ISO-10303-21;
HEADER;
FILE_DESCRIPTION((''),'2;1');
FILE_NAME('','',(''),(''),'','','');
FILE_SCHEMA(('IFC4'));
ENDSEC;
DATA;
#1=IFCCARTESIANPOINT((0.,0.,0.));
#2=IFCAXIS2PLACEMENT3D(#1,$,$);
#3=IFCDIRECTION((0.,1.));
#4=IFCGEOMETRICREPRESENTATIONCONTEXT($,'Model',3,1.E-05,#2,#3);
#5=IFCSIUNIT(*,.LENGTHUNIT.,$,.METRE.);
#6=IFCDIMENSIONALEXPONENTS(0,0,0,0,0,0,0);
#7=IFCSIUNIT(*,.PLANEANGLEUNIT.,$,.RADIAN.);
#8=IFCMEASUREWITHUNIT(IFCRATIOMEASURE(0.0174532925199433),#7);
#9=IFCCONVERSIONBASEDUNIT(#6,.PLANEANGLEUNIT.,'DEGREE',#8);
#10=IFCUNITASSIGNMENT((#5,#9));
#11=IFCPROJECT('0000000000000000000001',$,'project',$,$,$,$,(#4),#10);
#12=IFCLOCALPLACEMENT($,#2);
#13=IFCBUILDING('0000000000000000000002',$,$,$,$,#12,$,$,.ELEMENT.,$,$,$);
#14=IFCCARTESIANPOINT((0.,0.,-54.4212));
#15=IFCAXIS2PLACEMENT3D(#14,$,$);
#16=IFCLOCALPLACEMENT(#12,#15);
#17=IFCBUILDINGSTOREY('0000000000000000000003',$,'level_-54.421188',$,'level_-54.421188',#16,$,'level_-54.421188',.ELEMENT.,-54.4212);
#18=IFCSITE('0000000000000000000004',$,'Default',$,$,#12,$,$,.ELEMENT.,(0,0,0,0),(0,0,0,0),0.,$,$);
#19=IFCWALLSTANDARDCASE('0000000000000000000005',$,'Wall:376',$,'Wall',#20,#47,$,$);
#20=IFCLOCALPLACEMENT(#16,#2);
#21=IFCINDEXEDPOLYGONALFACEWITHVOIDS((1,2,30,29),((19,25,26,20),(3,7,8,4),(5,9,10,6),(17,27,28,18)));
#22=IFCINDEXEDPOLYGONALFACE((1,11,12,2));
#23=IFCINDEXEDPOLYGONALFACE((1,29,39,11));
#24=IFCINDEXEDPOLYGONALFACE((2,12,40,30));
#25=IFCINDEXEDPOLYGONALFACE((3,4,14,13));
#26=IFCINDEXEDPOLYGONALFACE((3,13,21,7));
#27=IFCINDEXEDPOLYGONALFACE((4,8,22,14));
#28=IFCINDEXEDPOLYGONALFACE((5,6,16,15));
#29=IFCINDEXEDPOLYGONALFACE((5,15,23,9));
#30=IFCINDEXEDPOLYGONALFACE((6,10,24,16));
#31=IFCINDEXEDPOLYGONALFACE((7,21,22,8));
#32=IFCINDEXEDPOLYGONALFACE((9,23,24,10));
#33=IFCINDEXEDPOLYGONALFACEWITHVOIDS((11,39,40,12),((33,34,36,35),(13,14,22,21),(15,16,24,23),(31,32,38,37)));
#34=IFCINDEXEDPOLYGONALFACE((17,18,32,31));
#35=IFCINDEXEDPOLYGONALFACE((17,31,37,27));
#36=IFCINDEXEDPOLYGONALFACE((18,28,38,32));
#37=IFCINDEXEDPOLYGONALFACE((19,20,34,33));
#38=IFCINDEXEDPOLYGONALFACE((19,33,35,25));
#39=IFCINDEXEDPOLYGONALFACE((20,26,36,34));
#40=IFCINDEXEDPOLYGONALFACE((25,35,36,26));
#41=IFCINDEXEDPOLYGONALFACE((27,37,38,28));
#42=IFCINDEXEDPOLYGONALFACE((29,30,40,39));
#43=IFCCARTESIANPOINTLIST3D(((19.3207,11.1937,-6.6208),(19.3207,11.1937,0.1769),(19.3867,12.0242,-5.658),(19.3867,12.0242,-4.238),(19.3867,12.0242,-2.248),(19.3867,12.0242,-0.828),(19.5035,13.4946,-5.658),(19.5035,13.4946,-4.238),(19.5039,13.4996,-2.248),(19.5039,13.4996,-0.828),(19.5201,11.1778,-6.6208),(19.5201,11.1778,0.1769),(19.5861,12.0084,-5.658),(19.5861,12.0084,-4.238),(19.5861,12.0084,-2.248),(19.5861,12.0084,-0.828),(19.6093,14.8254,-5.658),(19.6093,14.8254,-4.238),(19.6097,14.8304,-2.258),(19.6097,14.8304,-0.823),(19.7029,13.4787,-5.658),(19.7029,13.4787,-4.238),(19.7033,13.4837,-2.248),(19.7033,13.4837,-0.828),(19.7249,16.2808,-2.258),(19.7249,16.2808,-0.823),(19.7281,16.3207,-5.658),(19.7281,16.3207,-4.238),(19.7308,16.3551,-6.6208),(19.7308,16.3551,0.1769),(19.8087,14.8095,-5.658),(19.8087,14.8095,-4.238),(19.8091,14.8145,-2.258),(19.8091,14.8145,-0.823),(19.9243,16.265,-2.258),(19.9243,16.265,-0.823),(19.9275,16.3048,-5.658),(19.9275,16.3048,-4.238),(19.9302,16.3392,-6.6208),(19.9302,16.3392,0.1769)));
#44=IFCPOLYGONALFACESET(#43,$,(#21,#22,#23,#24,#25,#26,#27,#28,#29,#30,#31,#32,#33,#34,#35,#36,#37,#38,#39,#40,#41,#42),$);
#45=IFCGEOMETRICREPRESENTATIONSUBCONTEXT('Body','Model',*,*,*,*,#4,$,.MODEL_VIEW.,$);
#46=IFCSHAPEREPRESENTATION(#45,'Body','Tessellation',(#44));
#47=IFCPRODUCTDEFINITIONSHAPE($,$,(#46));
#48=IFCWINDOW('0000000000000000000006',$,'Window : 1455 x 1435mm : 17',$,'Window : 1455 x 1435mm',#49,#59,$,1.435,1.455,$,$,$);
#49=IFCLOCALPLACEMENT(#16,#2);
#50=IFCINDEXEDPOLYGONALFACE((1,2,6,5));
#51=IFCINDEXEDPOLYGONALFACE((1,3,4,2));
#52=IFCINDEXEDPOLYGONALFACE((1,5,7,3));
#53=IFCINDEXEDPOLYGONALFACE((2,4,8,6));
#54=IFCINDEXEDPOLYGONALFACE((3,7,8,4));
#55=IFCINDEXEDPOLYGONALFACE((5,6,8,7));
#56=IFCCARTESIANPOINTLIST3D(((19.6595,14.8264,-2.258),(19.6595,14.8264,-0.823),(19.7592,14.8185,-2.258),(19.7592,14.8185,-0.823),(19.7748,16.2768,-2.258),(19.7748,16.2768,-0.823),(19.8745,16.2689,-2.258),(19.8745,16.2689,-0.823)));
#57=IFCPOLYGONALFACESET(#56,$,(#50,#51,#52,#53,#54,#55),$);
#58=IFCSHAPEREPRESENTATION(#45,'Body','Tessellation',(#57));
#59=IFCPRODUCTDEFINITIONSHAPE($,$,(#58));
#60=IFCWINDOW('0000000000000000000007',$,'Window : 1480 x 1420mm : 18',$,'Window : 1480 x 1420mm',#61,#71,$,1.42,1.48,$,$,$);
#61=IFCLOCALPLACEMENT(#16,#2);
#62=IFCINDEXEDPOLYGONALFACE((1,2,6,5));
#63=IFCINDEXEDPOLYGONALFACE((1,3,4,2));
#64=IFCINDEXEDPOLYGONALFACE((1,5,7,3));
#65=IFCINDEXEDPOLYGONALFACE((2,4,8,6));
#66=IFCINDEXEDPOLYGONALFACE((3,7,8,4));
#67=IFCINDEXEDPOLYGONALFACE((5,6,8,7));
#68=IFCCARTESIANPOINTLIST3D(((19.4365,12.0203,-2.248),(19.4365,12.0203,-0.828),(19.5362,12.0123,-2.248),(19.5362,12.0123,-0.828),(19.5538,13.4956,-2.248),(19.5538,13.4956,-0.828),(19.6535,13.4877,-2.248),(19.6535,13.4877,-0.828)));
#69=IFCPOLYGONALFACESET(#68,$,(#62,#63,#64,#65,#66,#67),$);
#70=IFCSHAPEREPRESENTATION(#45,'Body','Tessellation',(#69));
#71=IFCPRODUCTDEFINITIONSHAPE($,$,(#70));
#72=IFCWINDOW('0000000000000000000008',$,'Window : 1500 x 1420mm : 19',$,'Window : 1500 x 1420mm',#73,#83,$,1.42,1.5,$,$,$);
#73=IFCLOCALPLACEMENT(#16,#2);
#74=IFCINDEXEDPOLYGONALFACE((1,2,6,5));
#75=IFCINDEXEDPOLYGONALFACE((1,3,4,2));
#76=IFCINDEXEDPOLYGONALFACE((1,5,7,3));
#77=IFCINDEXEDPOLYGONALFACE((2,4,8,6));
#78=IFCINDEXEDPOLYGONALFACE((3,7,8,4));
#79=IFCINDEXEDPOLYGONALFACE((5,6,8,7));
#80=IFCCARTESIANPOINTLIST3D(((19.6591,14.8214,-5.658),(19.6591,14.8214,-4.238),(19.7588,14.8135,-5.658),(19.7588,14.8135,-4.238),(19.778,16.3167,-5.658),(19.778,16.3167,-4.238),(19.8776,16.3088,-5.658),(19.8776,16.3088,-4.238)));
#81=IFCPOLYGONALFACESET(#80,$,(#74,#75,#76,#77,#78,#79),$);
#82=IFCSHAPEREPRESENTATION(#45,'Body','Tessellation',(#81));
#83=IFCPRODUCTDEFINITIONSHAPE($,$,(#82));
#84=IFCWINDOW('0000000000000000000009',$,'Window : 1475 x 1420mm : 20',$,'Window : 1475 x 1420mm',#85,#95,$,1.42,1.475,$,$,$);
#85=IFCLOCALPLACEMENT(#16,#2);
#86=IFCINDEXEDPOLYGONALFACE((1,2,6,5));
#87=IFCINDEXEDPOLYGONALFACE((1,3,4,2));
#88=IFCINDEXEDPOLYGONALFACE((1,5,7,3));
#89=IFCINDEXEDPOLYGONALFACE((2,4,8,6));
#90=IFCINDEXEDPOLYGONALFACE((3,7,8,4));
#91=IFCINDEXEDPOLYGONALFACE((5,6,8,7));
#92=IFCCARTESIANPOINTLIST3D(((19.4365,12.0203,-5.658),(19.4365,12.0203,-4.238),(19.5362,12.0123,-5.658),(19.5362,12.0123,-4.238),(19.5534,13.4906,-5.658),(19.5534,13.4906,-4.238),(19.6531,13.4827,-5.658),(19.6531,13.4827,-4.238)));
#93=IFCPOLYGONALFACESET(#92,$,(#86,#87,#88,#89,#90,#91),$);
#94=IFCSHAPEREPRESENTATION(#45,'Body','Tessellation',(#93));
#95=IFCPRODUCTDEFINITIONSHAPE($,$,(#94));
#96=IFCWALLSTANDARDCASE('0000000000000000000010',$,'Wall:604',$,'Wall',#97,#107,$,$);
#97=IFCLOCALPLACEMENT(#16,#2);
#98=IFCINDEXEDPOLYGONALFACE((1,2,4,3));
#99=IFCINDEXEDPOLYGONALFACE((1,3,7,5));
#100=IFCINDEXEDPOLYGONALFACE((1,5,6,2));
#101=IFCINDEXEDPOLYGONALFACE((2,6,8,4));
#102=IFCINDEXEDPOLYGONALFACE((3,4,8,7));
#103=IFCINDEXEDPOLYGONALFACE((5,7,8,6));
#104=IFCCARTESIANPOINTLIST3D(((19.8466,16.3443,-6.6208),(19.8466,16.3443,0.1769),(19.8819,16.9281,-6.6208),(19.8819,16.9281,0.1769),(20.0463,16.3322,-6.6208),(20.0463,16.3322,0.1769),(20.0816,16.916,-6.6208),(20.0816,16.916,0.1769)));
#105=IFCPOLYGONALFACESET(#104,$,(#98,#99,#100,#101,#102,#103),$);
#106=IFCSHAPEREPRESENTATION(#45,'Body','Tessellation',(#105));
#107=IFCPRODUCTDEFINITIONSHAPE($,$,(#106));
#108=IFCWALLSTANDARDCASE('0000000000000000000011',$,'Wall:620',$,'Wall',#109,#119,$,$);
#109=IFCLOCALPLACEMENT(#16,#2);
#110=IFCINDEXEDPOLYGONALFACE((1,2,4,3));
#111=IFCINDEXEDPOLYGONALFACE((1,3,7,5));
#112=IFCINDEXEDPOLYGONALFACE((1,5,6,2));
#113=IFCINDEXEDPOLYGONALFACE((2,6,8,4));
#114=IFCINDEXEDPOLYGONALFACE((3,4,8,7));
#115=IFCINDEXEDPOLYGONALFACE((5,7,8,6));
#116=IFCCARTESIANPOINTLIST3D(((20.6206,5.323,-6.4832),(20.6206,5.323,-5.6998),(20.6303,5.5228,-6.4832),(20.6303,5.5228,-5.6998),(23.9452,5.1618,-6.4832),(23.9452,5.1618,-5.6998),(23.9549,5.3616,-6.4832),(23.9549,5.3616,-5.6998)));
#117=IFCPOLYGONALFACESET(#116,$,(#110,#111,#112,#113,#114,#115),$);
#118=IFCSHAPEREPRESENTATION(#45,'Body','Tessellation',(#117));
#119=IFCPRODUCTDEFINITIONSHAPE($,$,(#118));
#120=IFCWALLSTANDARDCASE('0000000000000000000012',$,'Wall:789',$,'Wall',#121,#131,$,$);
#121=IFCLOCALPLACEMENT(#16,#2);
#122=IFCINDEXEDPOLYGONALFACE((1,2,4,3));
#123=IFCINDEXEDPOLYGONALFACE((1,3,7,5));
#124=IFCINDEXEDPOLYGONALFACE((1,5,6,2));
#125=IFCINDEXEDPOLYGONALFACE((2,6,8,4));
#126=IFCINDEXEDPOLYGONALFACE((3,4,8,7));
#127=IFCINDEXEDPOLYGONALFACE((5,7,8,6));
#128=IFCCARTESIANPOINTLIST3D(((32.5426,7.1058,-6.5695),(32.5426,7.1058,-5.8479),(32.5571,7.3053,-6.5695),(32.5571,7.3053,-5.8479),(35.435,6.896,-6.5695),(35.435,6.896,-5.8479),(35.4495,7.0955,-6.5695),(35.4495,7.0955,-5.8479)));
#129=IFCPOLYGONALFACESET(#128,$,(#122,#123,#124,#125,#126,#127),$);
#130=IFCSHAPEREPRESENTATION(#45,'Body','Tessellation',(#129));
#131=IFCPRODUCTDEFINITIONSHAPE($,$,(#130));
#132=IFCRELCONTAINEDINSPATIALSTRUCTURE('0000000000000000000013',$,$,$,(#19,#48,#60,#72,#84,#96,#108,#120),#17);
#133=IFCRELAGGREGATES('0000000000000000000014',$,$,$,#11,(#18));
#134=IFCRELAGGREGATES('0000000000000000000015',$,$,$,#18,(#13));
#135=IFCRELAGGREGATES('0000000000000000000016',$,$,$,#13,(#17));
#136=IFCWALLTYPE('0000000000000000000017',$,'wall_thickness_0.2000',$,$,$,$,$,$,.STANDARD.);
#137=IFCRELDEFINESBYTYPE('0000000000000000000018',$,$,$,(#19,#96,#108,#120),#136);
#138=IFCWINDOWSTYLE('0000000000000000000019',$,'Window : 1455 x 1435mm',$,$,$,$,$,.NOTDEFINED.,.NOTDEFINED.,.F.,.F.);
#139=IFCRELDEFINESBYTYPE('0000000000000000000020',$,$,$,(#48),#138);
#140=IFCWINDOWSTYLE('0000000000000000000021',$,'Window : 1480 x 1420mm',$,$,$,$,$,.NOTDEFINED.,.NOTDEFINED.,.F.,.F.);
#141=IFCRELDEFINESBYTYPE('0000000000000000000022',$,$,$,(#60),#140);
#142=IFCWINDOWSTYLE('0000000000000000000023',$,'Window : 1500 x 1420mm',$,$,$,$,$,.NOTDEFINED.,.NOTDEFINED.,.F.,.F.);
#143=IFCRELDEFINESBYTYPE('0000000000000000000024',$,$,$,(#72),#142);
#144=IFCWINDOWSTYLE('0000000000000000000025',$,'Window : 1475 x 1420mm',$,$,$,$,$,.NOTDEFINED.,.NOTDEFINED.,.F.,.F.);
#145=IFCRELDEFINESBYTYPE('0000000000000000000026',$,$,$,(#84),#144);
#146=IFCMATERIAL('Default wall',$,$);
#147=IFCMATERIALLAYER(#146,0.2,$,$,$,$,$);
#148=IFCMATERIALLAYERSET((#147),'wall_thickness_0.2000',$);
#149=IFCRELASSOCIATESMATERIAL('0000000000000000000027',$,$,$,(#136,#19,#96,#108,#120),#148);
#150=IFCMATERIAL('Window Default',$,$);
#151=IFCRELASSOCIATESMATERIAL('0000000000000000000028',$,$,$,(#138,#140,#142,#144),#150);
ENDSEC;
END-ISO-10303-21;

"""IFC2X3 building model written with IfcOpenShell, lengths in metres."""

from ifc_helpers import new_model, entity, si_unit, converted_unit, direction, frame, frame_2d, origin, origin_2d_with_axis, place, context, subcontext, project, spatial, polyline, rectangle, outline, extrude, source, transform, mapped, material, layer, layer_set, layer_usage, type_object, type_shapes, element, fill, save


model = new_model("IFC2X3")

# Units and contexts
model_context = context("Model", 3, precision=1e-05, world=origin(), true_north=direction((0.0, 1.0)))
body_context = subcontext(model_context, "Body", "Model", "MODEL_VIEW")
ifc_project = project(units=[si_unit("LENGTHUNIT", "METRE"), converted_unit("PLANEANGLEUNIT", "DEGREE", entity("IfcRatioMeasure", 0.0174532925199433), si_unit("PLANEANGLEUNIT", "RADIAN"), dimensions=[0, 0, 0, 0, 0, 0, 0])], contexts=[model_context])

# Site, building, storey
placement_1 = place(None, origin())
site = spatial("IfcSite", under=ifc_project, at=placement_1, Name="Default", CompositionType="ELEMENT", RefLatitude=(0, 0, 0, 0), RefLongitude=(0, 0, 0, 0), RefElevation=0.0)
building = spatial("IfcBuilding", under=site, at=placement_1, CompositionType="ELEMENT")
storey_placement = place(placement_1, frame((0.0, 0.0, -54.4212)))
storey = spatial("IfcBuildingStorey", under=building, at=storey_placement, Name="level_-54.421188", ObjectType="level_-54.421188", LongName="level_-54.421188", CompositionType="ELEMENT", Elevation=-54.4212)

# Wall, openings, windows
ifc_material_1 = material(Name="Default wall")
ifc_layer = layer(ifc_material_1, 0.2)
ifc_layer_set = layer_set([ifc_layer], Name="wall_thickness_0.2000")
ifc_layer_usage = layer_usage(ifc_layer_set, "AXIS2", "POSITIVE", -0.1)
wall_type = type_object("IfcWallType", Name="wall_thickness_0.2000", PredefinedType="STANDARD", material=ifc_layer_set)
placement_2 = place(placement_1, frame((0.0, 0.0, -61.042)))
wall_1_placement = place(placement_2, frame((19.8305, 16.3471, 0.0), z_axis=(0.0, 0.0, 1.0), x_axis=(-0.079214, -0.996858, 0.0)))
wall_1 = element("IfcWallStandardCase", 1, at=wall_1_placement, inside=storey, type_object=wall_type, material=ifc_layer_usage, Name="Wall:376", ObjectType="Wall", context=body_context, shape_type="SweptSolid", body=[
    extrude(outline(polyline([(5.1777, -0.1), (5.1777, 0.1), (0.0, 0.1), (0.0, -0.1), (5.1777, -0.1)])), origin(), (0.0, 0.0, 1.0), 6.7978),
])
opening_1_placement = place(wall_1_placement, frame((0.0745, -0.1, 4.3629)))
opening_1 = element("IfcOpeningElement", 2, at=opening_1_placement, cuts=wall_1, ObjectType="Opening", context=body_context, shape_type="SweptSolid", body=[
    extrude(rectangle(XDim=1.455, YDim=1.435, at=frame_2d((0.7175, 0.7275), x_axis=(0.0, 1.0))), frame((0.0, 0.0, 0.0), z_axis=(0.0, 1.0, 0.0), x_axis=(0.0, 0.0, 1.0)), (0.0, 0.0, 1.0), 0.2),
])
opening_2_placement = place(wall_1_placement, frame((2.8645, -0.1, 4.3729)))
opening_2 = element("IfcOpeningElement", 3, at=opening_2_placement, cuts=wall_1, ObjectType="Opening", context=body_context, shape_type="SweptSolid", body=[
    extrude(rectangle(XDim=1.48, YDim=1.42, at=frame_2d((0.71, 0.74), x_axis=(0.0, 1.0))), frame((0.0, 0.0, 0.0), z_axis=(0.0, 1.0, 0.0), x_axis=(0.0, 0.0, 1.0)), (0.0, 0.0, 1.0), 0.2),
])
opening_3_placement = place(wall_1_placement, frame((0.0345, -0.1, 0.9629)))
opening_3 = element("IfcOpeningElement", 4, at=opening_3_placement, cuts=wall_1, ObjectType="Opening", context=body_context, shape_type="SweptSolid", body=[
    extrude(rectangle(XDim=1.5, YDim=1.42, at=frame_2d((0.71, 0.75), x_axis=(0.0, 1.0))), frame((0.0, 0.0, 0.0), z_axis=(0.0, 1.0, 0.0), x_axis=(0.0, 0.0, 1.0)), (0.0, 0.0, 1.0), 0.2),
])
opening_4_placement = place(wall_1_placement, frame((2.8695, -0.1, 0.9629)))
opening_4 = element("IfcOpeningElement", 5, at=opening_4_placement, cuts=wall_1, ObjectType="Opening", context=body_context, shape_type="SweptSolid", body=[
    extrude(rectangle(XDim=1.475, YDim=1.42, at=frame_2d((0.71, 0.7375), x_axis=(0.0, 1.0))), frame((0.0, 0.0, 0.0), z_axis=(0.0, 1.0, 0.0), x_axis=(0.0, 0.0, 1.0)), (0.0, 0.0, 1.0), 0.2),
])
ifc_material_2 = material(Name="Window Default")
window_style_1 = type_object("IfcWindowStyle", Name="Window : 1455 x 1435mm", ConstructionType="NOTDEFINED", OperationType="NOTDEFINED", ParameterTakesPrecedence=False, Sizeable=False, material=ifc_material_2)
shared_shape_1 = source(origin(), body_context, "Body", "SweptSolid", [
    extrude(rectangle(XDim=0.1, YDim=1.455, at=origin_2d_with_axis()), frame((0.7275, 0.1, 0.0), z_axis=(0.0, 0.0, 1.0), x_axis=(0.0, 1.0, 0.0)), (0.0, 0.0, 1.0), 1.435),
])
type_shapes(window_style_1, [shared_shape_1])
window_1_placement = place(opening_1_placement, origin())
window_1 = element("IfcWindow", 6, at=window_1_placement, inside=storey, type_object=window_style_1, Name="Window : 1455 x 1435mm : 17", ObjectType="Window : 1455 x 1435mm", OverallHeight=1.435, OverallWidth=1.455, context=body_context, shape_type="MappedRepresentation", body=[
    mapped(shared_shape_1, transform((0.0, 0.0, 0.0), scale=1.0)),
])
fill(opening_1, window_1)
window_style_2 = type_object("IfcWindowStyle", Name="Window : 1480 x 1420mm", ConstructionType="NOTDEFINED", OperationType="NOTDEFINED", ParameterTakesPrecedence=False, Sizeable=False, material=ifc_material_2)
shared_shape_2 = source(origin(), body_context, "Body", "SweptSolid", [
    extrude(rectangle(XDim=0.1, YDim=1.48, at=origin_2d_with_axis()), frame((0.74, 0.1, 0.0), z_axis=(0.0, 0.0, 1.0), x_axis=(0.0, 1.0, 0.0)), (0.0, 0.0, 1.0), 1.42),
])
type_shapes(window_style_2, [shared_shape_2])
window_2_placement = place(opening_2_placement, origin())
window_2 = element("IfcWindow", 7, at=window_2_placement, inside=storey, type_object=window_style_2, Name="Window : 1480 x 1420mm : 18", ObjectType="Window : 1480 x 1420mm", OverallHeight=1.42, OverallWidth=1.48, context=body_context, shape_type="MappedRepresentation", body=[
    mapped(shared_shape_2, transform((0.0, 0.0, 0.0), scale=1.0)),
])
fill(opening_2, window_2)
window_style_3 = type_object("IfcWindowStyle", Name="Window : 1500 x 1420mm", ConstructionType="NOTDEFINED", OperationType="NOTDEFINED", ParameterTakesPrecedence=False, Sizeable=False, material=ifc_material_2)
shared_shape_3 = source(origin(), body_context, "Body", "SweptSolid", [
    extrude(rectangle(XDim=0.1, YDim=1.5, at=origin_2d_with_axis()), frame((0.75, 0.1, 0.0), z_axis=(0.0, 0.0, 1.0), x_axis=(0.0, 1.0, 0.0)), (0.0, 0.0, 1.0), 1.42),
])
type_shapes(window_style_3, [shared_shape_3])
window_3_placement = place(opening_3_placement, origin())
window_3 = element("IfcWindow", 8, at=window_3_placement, inside=storey, type_object=window_style_3, Name="Window : 1500 x 1420mm : 19", ObjectType="Window : 1500 x 1420mm", OverallHeight=1.42, OverallWidth=1.5, context=body_context, shape_type="MappedRepresentation", body=[
    mapped(shared_shape_3, transform((0.0, 0.0, 0.0), scale=1.0)),
])
fill(opening_3, window_3)
window_style_4 = type_object("IfcWindowStyle", Name="Window : 1475 x 1420mm", ConstructionType="NOTDEFINED", OperationType="NOTDEFINED", ParameterTakesPrecedence=False, Sizeable=False, material=ifc_material_2)
shared_shape_4 = source(origin(), body_context, "Body", "SweptSolid", [
    extrude(rectangle(XDim=0.1, YDim=1.475, at=origin_2d_with_axis()), frame((0.7375, 0.1, 0.0), z_axis=(0.0, 0.0, 1.0), x_axis=(0.0, 1.0, 0.0)), (0.0, 0.0, 1.0), 1.42),
])
type_shapes(window_style_4, [shared_shape_4])
window_4_placement = place(opening_4_placement, origin())
window_4 = element("IfcWindow", 9, at=window_4_placement, inside=storey, type_object=window_style_4, Name="Window : 1475 x 1420mm : 20", ObjectType="Window : 1475 x 1420mm", OverallHeight=1.42, OverallWidth=1.475, context=body_context, shape_type="MappedRepresentation", body=[
    mapped(shared_shape_4, transform((0.0, 0.0, 0.0), scale=1.0)),
])
fill(opening_4, window_4)

# Walls
placement_3 = place(placement_1, frame((0.0, 0.0, -61.042)))
wall_2_placement = place(placement_3, frame((19.9818, 16.9221, 0.0), z_axis=(0.0, 0.0, 1.0), x_axis=(-0.060352, -0.998177, 0.0)))
element("IfcWallStandardCase", 10, at=wall_2_placement, inside=storey, type_object=wall_type, material=ifc_layer_usage, Name="Wall:604", ObjectType="Wall", context=body_context, shape_type="SweptSolid", body=[
    extrude(outline(polyline([(0.5849, -0.1), (0.5849, 0.1), (0.0, 0.1), (0.0, -0.1), (0.5849, -0.1)])), origin(), (0.0, 0.0, 1.0), 6.7978),
])
placement_4 = place(placement_1, frame((0.0, 0.0, -60.9044)))
wall_3_placement = place(placement_4, frame((20.6255, 5.4229, 0.0), z_axis=(0.0, 0.0, 1.0), x_axis=(0.998826, -0.048447, 0.0)))
element("IfcWallStandardCase", 11, at=wall_3_placement, inside=storey, type_object=wall_type, material=ifc_layer_usage, Name="Wall:620", ObjectType="Wall", context=body_context, shape_type="SweptSolid", body=[
    extrude(outline(polyline([(3.3285, -0.1), (3.3285, 0.1), (0.0, 0.1), (0.0, -0.1), (3.3285, -0.1)])), origin(), (0.0, 0.0, 1.0), 0.7835),
])
placement_5 = place(placement_1, frame((0.0, 0.0, -60.9907)))
wall_4_placement = place(placement_5, frame((32.5498, 7.2055, 0.0), z_axis=(0.0, 0.0, 1.0), x_axis=(0.997379, -0.072351, 0.0)))
element("IfcWallStandardCase", 12, at=wall_4_placement, inside=storey, type_object=wall_type, material=ifc_layer_usage, Name="Wall:789", ObjectType="Wall", context=body_context, shape_type="SweptSolid", body=[
    extrude(outline(polyline([(2.9, -0.1), (2.9, 0.1), (0.0, 0.1), (0.0, -0.1), (2.9, -0.1)])), origin(), (0.0, 0.0, 1.0), 0.7215),
])

save(model, "model.ifc")
